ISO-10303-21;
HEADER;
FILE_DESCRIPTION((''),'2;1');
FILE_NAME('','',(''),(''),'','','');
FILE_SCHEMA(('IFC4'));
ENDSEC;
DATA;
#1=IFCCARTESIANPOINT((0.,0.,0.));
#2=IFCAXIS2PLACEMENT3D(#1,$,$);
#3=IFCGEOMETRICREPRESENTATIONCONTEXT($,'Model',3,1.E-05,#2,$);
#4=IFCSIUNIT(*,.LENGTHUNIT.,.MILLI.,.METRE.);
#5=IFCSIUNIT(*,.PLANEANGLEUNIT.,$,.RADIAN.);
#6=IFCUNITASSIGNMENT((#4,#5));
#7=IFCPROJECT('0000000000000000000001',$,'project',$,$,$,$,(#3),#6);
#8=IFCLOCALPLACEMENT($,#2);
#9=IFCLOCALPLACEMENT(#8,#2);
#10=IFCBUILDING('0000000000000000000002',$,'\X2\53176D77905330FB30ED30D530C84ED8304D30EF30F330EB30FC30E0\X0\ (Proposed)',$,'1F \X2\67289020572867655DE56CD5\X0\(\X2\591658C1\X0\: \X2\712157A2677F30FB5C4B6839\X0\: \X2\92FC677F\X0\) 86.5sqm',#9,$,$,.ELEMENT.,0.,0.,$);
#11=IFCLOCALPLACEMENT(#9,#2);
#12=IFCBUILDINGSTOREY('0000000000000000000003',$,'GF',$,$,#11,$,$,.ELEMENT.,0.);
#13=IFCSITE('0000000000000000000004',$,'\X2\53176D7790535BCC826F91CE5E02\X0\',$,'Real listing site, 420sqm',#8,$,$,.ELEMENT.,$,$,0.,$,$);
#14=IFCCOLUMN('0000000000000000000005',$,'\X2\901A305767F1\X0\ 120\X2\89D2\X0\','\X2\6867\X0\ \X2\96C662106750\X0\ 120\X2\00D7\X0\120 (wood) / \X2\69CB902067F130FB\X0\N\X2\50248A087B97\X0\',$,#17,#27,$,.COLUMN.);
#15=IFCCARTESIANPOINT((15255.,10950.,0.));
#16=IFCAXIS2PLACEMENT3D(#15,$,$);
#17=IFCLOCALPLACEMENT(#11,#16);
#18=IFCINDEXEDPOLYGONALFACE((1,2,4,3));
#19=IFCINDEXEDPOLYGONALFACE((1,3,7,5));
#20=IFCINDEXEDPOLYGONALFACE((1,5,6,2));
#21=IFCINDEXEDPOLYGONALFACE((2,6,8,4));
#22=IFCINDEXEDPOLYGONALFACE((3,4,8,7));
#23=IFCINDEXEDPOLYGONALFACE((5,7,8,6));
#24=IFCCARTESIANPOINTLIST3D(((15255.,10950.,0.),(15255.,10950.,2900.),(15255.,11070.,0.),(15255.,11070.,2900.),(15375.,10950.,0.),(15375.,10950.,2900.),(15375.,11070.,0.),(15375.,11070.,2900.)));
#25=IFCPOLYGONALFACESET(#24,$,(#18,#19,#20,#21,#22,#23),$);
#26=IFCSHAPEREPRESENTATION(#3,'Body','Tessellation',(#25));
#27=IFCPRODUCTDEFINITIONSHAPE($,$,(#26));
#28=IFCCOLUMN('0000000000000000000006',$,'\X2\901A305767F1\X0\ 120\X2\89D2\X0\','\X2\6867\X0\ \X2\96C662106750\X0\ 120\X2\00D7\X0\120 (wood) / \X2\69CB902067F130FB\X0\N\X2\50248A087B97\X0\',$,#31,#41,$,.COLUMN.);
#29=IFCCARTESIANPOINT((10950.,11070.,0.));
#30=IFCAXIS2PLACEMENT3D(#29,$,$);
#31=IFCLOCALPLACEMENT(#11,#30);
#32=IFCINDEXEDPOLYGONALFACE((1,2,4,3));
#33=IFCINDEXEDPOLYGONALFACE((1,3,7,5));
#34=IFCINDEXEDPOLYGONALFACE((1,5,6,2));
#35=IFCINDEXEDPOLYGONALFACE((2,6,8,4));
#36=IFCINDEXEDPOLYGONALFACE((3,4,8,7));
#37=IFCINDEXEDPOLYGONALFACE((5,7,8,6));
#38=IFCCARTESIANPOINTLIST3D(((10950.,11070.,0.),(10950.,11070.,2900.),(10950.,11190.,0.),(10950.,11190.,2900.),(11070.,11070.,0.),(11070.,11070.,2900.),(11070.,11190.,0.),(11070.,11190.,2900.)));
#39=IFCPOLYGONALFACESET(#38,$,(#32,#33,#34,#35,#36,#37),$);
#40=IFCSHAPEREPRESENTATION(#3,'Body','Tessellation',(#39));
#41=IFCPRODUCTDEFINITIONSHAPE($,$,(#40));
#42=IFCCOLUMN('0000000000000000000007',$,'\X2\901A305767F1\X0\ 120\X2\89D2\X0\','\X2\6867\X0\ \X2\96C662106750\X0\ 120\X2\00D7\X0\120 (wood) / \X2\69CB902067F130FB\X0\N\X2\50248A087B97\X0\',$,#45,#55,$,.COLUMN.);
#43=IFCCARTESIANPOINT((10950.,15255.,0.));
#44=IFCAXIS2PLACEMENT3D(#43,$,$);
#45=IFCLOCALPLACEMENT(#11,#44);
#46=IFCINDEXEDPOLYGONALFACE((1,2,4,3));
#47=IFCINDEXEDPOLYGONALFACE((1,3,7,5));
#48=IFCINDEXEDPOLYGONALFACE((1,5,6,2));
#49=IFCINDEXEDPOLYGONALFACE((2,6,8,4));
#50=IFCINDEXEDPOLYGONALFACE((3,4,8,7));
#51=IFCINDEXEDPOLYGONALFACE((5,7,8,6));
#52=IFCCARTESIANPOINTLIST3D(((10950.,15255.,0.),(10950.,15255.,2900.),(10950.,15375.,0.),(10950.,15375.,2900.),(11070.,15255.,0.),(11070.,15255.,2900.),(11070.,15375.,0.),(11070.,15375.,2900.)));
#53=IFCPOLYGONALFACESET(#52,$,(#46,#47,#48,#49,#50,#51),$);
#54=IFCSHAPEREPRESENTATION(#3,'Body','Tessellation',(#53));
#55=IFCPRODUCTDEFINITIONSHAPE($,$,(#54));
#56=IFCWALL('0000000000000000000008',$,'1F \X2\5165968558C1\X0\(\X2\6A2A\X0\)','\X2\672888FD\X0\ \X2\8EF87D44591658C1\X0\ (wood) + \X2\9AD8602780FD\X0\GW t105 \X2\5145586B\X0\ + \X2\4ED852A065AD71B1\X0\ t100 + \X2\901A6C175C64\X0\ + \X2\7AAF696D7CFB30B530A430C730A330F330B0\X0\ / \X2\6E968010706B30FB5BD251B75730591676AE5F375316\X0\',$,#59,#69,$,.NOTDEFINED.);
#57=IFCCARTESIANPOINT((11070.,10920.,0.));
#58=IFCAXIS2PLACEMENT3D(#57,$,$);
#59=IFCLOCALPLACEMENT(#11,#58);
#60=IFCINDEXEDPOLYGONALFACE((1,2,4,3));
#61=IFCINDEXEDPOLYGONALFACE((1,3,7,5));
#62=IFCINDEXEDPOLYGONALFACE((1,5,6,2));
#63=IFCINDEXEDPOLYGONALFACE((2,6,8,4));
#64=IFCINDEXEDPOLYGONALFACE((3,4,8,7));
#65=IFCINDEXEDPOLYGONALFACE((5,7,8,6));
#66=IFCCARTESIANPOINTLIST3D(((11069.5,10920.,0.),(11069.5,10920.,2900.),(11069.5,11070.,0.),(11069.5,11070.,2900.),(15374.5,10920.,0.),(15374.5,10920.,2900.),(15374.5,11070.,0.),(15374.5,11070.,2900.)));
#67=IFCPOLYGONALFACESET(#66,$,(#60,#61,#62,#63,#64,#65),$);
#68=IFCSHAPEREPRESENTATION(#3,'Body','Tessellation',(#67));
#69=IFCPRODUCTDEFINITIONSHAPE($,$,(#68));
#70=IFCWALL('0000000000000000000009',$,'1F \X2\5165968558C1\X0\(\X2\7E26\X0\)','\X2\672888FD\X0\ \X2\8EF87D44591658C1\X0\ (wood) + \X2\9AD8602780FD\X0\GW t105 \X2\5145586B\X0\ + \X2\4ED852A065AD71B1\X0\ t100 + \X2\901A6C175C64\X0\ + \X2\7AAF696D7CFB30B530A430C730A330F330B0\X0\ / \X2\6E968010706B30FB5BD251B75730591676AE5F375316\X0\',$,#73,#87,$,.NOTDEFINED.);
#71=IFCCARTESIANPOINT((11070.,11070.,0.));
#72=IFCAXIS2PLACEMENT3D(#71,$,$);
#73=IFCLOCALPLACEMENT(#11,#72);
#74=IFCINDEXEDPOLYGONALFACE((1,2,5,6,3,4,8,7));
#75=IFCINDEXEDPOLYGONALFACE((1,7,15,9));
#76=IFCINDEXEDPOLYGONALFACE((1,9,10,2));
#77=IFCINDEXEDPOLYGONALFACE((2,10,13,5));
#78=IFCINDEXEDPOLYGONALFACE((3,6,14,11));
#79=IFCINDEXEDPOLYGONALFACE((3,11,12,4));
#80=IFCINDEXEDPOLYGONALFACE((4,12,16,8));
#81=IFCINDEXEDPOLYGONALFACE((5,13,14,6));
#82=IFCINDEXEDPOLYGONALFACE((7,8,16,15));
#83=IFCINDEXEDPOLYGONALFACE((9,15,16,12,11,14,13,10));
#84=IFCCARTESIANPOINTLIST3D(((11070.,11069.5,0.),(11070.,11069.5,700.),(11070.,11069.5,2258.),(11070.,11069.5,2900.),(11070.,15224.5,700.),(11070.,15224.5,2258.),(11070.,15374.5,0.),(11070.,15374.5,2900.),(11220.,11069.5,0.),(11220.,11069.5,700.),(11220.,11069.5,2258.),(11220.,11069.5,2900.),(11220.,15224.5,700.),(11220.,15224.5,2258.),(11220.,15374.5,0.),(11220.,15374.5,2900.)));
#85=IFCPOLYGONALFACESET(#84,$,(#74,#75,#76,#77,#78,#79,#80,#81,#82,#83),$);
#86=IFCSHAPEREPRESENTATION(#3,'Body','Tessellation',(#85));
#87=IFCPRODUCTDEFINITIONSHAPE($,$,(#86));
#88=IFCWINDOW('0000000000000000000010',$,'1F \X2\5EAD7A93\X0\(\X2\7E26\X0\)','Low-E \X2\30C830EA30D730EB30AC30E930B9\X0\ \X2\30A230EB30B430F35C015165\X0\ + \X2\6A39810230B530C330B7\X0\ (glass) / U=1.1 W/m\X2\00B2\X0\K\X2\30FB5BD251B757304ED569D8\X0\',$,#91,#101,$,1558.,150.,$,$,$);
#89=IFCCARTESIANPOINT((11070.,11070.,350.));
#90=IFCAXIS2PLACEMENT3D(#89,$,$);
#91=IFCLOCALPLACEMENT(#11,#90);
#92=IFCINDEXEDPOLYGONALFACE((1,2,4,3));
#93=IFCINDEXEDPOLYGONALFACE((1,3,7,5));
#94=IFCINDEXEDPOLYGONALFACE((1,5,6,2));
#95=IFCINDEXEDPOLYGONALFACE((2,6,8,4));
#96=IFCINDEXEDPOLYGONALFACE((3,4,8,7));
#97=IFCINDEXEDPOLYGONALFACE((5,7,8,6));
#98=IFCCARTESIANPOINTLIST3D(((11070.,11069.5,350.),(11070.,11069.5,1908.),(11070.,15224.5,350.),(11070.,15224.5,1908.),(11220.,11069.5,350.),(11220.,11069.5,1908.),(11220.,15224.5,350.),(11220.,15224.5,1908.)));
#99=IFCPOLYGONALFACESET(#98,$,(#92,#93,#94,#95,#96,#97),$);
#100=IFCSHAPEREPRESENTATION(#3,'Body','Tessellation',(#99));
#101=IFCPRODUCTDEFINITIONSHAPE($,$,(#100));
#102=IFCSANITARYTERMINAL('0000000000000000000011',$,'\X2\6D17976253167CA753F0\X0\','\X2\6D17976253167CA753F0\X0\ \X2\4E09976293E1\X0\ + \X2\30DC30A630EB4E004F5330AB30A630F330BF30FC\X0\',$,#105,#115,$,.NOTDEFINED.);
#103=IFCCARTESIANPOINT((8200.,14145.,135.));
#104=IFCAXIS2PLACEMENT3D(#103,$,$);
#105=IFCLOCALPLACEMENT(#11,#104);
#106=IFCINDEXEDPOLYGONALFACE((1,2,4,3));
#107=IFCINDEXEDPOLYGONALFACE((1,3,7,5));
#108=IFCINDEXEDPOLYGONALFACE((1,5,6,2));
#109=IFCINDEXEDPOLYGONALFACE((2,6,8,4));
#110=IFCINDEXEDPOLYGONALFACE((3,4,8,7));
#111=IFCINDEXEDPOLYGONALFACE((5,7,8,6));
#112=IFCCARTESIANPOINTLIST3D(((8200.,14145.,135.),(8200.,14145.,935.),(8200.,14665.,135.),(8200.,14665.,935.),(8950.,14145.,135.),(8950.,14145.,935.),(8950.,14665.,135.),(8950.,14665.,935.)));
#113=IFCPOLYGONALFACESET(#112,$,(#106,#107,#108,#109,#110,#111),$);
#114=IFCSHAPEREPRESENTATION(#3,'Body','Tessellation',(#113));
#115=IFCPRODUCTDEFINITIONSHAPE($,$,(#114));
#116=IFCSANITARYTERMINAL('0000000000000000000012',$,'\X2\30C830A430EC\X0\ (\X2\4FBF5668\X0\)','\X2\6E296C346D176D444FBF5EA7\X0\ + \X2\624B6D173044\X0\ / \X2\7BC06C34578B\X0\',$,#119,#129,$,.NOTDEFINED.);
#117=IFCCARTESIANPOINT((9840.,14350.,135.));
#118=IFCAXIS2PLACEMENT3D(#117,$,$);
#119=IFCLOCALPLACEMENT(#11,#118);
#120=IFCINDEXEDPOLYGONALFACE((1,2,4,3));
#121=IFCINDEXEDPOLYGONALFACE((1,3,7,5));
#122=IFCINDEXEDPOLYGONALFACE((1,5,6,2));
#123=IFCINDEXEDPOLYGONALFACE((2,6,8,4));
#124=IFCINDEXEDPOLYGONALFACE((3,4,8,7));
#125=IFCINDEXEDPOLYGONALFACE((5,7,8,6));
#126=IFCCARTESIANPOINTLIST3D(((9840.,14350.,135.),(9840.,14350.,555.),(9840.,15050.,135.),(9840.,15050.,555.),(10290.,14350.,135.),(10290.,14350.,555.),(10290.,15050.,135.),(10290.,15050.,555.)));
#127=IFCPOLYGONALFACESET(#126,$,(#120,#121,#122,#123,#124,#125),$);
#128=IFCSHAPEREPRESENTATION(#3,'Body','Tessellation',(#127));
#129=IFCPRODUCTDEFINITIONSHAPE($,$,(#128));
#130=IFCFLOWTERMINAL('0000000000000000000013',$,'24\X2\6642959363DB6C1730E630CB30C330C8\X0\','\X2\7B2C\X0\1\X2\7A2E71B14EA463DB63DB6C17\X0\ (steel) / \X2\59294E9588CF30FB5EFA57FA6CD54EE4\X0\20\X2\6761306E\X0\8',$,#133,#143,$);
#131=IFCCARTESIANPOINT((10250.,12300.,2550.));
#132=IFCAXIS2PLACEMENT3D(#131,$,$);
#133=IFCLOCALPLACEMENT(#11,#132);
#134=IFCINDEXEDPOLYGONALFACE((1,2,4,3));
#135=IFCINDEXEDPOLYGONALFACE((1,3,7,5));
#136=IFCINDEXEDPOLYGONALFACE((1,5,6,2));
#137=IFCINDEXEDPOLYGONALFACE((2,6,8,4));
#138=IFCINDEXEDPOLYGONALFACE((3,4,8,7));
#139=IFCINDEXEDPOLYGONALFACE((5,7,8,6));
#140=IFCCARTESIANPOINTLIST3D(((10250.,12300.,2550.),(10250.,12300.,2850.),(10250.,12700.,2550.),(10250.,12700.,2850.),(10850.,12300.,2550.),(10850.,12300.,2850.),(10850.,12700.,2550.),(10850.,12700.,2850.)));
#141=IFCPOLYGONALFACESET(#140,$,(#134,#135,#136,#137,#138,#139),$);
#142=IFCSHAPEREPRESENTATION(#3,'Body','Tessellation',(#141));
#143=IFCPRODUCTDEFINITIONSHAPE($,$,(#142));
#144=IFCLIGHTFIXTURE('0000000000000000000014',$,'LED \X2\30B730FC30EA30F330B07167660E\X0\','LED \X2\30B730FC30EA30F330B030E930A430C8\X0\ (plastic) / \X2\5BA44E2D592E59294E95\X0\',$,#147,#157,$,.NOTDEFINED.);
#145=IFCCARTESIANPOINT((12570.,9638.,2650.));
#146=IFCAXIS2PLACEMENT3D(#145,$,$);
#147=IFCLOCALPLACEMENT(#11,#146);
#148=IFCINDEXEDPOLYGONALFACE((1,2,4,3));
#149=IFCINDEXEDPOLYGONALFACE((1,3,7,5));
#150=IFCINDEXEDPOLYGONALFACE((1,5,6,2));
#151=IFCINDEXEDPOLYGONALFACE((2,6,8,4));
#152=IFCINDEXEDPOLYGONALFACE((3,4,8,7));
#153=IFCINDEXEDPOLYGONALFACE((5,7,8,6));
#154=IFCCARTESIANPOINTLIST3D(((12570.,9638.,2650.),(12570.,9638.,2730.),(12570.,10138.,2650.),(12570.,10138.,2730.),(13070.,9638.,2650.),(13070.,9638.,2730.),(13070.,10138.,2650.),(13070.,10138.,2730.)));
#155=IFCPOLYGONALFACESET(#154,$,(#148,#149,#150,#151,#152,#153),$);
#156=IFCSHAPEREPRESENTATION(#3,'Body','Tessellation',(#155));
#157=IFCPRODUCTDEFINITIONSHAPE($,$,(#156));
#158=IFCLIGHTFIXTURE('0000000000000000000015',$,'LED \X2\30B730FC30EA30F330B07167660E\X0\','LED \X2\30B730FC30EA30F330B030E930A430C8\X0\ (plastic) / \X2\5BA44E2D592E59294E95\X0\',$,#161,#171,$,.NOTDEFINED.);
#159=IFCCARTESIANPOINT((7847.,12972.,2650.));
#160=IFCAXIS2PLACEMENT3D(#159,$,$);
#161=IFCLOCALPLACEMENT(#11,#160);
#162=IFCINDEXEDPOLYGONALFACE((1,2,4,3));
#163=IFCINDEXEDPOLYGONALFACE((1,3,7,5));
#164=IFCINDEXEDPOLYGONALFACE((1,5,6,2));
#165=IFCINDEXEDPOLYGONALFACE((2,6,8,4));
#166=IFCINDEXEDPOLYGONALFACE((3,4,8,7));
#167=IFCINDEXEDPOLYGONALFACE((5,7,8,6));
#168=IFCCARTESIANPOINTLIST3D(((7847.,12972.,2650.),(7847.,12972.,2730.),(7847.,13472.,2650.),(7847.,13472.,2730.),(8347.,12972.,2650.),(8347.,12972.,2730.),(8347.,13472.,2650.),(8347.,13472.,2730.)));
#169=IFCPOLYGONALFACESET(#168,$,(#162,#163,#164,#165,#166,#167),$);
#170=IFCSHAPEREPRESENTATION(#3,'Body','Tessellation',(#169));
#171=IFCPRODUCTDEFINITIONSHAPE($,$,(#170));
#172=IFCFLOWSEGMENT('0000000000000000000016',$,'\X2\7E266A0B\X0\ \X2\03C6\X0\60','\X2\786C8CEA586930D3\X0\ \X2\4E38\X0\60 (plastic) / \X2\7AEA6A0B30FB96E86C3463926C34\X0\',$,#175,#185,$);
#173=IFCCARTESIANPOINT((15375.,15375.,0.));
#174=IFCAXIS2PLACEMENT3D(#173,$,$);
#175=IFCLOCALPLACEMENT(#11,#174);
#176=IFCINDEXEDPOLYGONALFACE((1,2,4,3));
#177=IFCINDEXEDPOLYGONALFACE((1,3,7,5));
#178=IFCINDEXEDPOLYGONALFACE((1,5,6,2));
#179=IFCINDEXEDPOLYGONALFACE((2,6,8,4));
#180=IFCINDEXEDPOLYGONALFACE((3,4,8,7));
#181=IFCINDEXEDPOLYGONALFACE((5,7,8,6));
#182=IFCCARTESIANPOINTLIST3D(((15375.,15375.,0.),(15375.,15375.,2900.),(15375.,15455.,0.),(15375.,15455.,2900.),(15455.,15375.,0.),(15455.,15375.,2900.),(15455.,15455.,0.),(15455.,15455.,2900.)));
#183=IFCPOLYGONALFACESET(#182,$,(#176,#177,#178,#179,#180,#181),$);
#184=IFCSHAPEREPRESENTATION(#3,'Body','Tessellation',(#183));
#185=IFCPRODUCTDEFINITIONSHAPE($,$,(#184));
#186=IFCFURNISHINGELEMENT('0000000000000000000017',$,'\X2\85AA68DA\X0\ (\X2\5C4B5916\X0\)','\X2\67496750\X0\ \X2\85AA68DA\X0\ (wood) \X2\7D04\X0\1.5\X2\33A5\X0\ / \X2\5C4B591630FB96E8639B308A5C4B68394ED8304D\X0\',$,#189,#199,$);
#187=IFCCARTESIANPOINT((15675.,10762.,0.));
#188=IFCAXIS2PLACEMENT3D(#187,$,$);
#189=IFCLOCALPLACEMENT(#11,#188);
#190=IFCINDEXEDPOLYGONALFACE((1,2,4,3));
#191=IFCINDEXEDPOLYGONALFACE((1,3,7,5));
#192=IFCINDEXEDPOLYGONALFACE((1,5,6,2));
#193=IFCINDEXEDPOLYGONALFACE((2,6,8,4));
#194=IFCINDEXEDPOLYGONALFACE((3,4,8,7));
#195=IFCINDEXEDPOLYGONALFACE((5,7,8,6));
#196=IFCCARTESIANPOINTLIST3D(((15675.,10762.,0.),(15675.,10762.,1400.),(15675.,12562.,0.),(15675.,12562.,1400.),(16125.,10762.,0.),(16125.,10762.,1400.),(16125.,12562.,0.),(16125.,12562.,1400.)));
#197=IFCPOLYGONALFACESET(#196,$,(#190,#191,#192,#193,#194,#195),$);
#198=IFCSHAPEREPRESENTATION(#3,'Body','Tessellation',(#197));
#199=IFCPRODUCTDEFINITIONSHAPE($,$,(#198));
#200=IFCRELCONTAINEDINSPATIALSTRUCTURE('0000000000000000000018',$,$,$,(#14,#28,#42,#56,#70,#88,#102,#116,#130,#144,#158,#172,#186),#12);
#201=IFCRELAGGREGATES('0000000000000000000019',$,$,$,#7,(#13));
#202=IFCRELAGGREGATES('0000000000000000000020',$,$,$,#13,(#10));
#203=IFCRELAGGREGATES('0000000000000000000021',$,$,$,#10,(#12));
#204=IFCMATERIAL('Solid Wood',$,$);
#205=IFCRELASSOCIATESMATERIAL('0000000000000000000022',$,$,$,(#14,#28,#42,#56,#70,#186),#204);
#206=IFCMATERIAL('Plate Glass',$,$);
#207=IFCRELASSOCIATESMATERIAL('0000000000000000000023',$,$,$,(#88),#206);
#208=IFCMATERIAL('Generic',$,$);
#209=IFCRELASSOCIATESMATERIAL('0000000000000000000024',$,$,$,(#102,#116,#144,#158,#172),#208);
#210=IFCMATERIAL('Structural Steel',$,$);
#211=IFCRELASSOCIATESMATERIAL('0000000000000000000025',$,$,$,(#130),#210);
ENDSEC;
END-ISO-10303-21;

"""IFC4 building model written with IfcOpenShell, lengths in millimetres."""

from ifc_helpers import new_model, si_unit, frame, frame_2d, origin, place, context, project, spatial, rectangle, extrude, material, element, fill, save


model = new_model("IFC4")

# Units and contexts
model_context = context("Model", 3, precision=1e-05, world=origin())
ifc_project = project(units=[si_unit("LENGTHUNIT", "METRE", prefix="MILLI"), si_unit("PLANEANGLEUNIT", "RADIAN")], contexts=[model_context])

# Site, building, storey
site_placement = place(None, origin())
site = spatial("IfcSite", under=ifc_project, at=site_placement, Name="北海道富良野市", ObjectType="Real listing site, 420sqm", CompositionType="ELEMENT", RefElevation=0.0)
building_placement = place(site_placement, origin())
building = spatial("IfcBuilding", under=site, at=building_placement, Name="北海道・ロフト付きワンルーム (Proposed)", ObjectType="1F 木造在来工法(外壁: 無垢板・屋根: 鋼板) 86.5sqm", CompositionType="ELEMENT", ElevationOfRefHeight=0.0, ElevationOfTerrain=0.0)
storey_placement = place(building_placement, origin())
storey = spatial("IfcBuildingStorey", under=building, at=storey_placement, Name="GF", CompositionType="ELEMENT", Elevation=0.0)

# Columns
ifc_material_1 = material(Name="Solid Wood")
column_1_placement = place(storey_placement, frame((15255.0, 10950.0, 0.0)))
element("IfcColumn", 1, at=column_1_placement, inside=storey, material=ifc_material_1, Name="通し柱 120角", Description="桧 集成材 120×120 (wood) / 構造柱・N値計算", PredefinedType="COLUMN", context=model_context, shape_type="SweptSolid", body=[
    extrude(rectangle(XDim=120.0, YDim=120.0, at=frame_2d((60.0, 60.0))), frame((15255.0, 10950.0, 0.0)), (0.0, 0.0, 1.0), 2900.0),
])
column_2_placement = place(storey_placement, frame((10950.0, 11070.0, 0.0)))
element("IfcColumn", 2, at=column_2_placement, inside=storey, material=ifc_material_1, Name="通し柱 120角", Description="桧 集成材 120×120 (wood) / 構造柱・N値計算", PredefinedType="COLUMN", context=model_context, shape_type="SweptSolid", body=[
    extrude(rectangle(XDim=120.0, YDim=120.0, at=frame_2d((60.0, 60.0))), frame((10950.0, 11070.0, 0.0)), (0.0, 0.0, 1.0), 2900.0),
])
column_3_placement = place(storey_placement, frame((10950.0, 15255.0, 0.0)))
element("IfcColumn", 3, at=column_3_placement, inside=storey, material=ifc_material_1, Name="通し柱 120角", Description="桧 集成材 120×120 (wood) / 構造柱・N値計算", PredefinedType="COLUMN", context=model_context, shape_type="SweptSolid", body=[
    extrude(rectangle(XDim=120.0, YDim=120.0, at=frame_2d((60.0, 60.0))), frame((10950.0, 15255.0, 0.0)), (0.0, 0.0, 1.0), 2900.0),
])

# Wall
wall_1_placement = place(storey_placement, frame((11070.0, 10920.0, 0.0)))
element("IfcWall", 4, at=wall_1_placement, inside=storey, material=ifc_material_1, Name="1F 入隅壁(横)", Description="木製 軸組外壁 (wood) + 高性能GW t105 充填 + 付加断熱 t100 + 通気層 + 窯業系サイディング / 準耐火・寒冷地外皮強化", PredefinedType="NOTDEFINED", context=model_context, shape_type="SweptSolid", body=[
    extrude(rectangle(XDim=4305.0, YDim=150.0, at=frame_2d((2152.0, 75.0))), frame((11070.0, 10920.0, 0.0)), (0.0, 0.0, 1.0), 2900.0),
])

# Wall, opening, window
wall_2_placement = place(storey_placement, frame((11070.0, 11070.0, 0.0)))
wall_2 = element("IfcWall", 5, at=wall_2_placement, inside=storey, material=ifc_material_1, Name="1F 入隅壁(縦)", Description="木製 軸組外壁 (wood) + 高性能GW t105 充填 + 付加断熱 t100 + 通気層 + 窯業系サイディング / 準耐火・寒冷地外皮強化", PredefinedType="NOTDEFINED", context=model_context, shape_type="SweptSolid", body=[
    extrude(rectangle(XDim=150.0, YDim=4305.0, at=frame_2d((75.0, 2152.0))), frame((11070.0, 11070.0, 0.0)), (0.0, 0.0, 1.0), 2900.0),
])
opening_placement = place(storey_placement, frame((11070.0, 11070.0, 350.0)))
opening = element("IfcOpeningElement", 6, at=opening_placement, cuts=wall_2, PredefinedType="NOTDEFINED", context=model_context, shape_type="SweptSolid", body=[
    extrude(rectangle(XDim=150.0, YDim=4155.0, at=frame_2d((75.0, 2077.0))), frame((11070.0, 11070.0, 350.0)), (0.0, 0.0, 1.0), 1558.0),
])
ifc_material_2 = material(Name="Plate Glass")
window_placement = place(storey_placement, frame((11070.0, 11070.0, 350.0)))
window = element("IfcWindow", 7, at=window_placement, inside=storey, material=ifc_material_2, Name="1F 庭窓(縦)", Description="Low-E トリプルガラス アルゴン封入 + 樹脂サッシ (glass) / U=1.1 W/m²K・寒冷地仕様", OverallHeight=1558.0, OverallWidth=150.0, context=model_context, shape_type="SweptSolid", body=[
    extrude(rectangle(XDim=150.0, YDim=4155.0, at=frame_2d((75.0, 2077.0))), frame((11070.0, 11070.0, 350.0)), (0.0, 0.0, 1.0), 1558.0),
])
fill(opening, window)

# Sanitary terminals
ifc_material_3 = material(Name="Generic")
sanitary_terminal_1_placement = place(storey_placement, frame((8200.0, 14145.0, 135.0)))
element("IfcSanitaryTerminal", 8, at=sanitary_terminal_1_placement, inside=storey, material=ifc_material_3, Name="洗面化粧台", Description="洗面化粧台 三面鏡 + ボウル一体カウンター", PredefinedType="NOTDEFINED", context=model_context, shape_type="SweptSolid", body=[
    extrude(rectangle(XDim=750.0, YDim=520.0, at=frame_2d((375.0, 260.0))), frame((8200.0, 14145.0, 135.0)), (0.0, 0.0, 1.0), 800.0),
])
sanitary_terminal_2_placement = place(storey_placement, frame((9840.0, 14350.0, 135.0)))
element("IfcSanitaryTerminal", 9, at=sanitary_terminal_2_placement, inside=storey, material=ifc_material_3, Name="トイレ (便器)", Description="温水洗浄便座 + 手洗い / 節水型", PredefinedType="NOTDEFINED", context=model_context, shape_type="SweptSolid", body=[
    extrude(rectangle(XDim=450.0, YDim=700.0, at=frame_2d((225.0, 350.0))), frame((9840.0, 14350.0, 135.0)), (0.0, 0.0, 1.0), 420.0),
])

# Flow terminal
ifc_material_4 = material(Name="Structural Steel")
flow_terminal_placement = place(storey_placement, frame((10250.0, 12300.0, 2550.0)))
element("IfcFlowTerminal", 10, at=flow_terminal_placement, inside=storey, material=ifc_material_4, Name="24時間換気ユニット", Description="第1種熱交換換気 (steel) / 天井裏・建基法令20条の8", context=model_context, shape_type="SweptSolid", body=[
    extrude(rectangle(XDim=600.0, YDim=400.0, at=frame_2d((300.0, 200.0))), frame((10250.0, 12300.0, 2550.0)), (0.0, 0.0, 1.0), 300.0),
])

# Light fixtures
light_fixture_1_placement = place(storey_placement, frame((12570.0, 9638.0, 2650.0)))
element("IfcLightFixture", 11, at=light_fixture_1_placement, inside=storey, material=ifc_material_3, Name="LED シーリング照明", Description="LED シーリングライト (plastic) / 室中央天井", PredefinedType="NOTDEFINED", context=model_context, shape_type="SweptSolid", body=[
    extrude(rectangle(XDim=500.0, YDim=500.0, at=frame_2d((250.0, 250.0))), frame((12570.0, 9638.0, 2650.0)), (0.0, 0.0, 1.0), 80.0),
])
light_fixture_2_placement = place(storey_placement, frame((7847.0, 12972.0, 2650.0)))
element("IfcLightFixture", 12, at=light_fixture_2_placement, inside=storey, material=ifc_material_3, Name="LED シーリング照明", Description="LED シーリングライト (plastic) / 室中央天井", PredefinedType="NOTDEFINED", context=model_context, shape_type="SweptSolid", body=[
    extrude(rectangle(XDim=500.0, YDim=500.0, at=frame_2d((250.0, 250.0))), frame((7847.0, 12972.0, 2650.0)), (0.0, 0.0, 1.0), 80.0),
])

# Flow segment
flow_segment_placement = place(storey_placement, frame((15375.0, 15375.0, 0.0)))
element("IfcFlowSegment", 13, at=flow_segment_placement, inside=storey, material=ifc_material_3, Name="縦樋 φ60", Description="硬質塩ビ 丸60 (plastic) / 竪樋・雨水排水", context=model_context, shape_type="SweptSolid", body=[
    extrude(rectangle(XDim=80.0, YDim=80.0, at=frame_2d((40.0, 40.0))), frame((15375.0, 15375.0, 0.0)), (0.0, 0.0, 1.0), 2900.0),
])

# Furnishing element
furnishing_placement = place(storey_placement, frame((15675.0, 10762.0, 0.0)))
element("IfcFurnishingElement", 14, at=furnishing_placement, inside=storey, material=ifc_material_1, Name="薪棚 (屋外)", Description="杉材 薪棚 (wood) 約1.5㎥ / 屋外・雨掛り屋根付き", context=model_context, shape_type="SweptSolid", body=[
    extrude(rectangle(XDim=450.0, YDim=1800.0, at=frame_2d((225.0, 900.0))), frame((15675.0, 10762.0, 0.0)), (0.0, 0.0, 1.0), 1400.0),
])

save(model, "model.ifc")
